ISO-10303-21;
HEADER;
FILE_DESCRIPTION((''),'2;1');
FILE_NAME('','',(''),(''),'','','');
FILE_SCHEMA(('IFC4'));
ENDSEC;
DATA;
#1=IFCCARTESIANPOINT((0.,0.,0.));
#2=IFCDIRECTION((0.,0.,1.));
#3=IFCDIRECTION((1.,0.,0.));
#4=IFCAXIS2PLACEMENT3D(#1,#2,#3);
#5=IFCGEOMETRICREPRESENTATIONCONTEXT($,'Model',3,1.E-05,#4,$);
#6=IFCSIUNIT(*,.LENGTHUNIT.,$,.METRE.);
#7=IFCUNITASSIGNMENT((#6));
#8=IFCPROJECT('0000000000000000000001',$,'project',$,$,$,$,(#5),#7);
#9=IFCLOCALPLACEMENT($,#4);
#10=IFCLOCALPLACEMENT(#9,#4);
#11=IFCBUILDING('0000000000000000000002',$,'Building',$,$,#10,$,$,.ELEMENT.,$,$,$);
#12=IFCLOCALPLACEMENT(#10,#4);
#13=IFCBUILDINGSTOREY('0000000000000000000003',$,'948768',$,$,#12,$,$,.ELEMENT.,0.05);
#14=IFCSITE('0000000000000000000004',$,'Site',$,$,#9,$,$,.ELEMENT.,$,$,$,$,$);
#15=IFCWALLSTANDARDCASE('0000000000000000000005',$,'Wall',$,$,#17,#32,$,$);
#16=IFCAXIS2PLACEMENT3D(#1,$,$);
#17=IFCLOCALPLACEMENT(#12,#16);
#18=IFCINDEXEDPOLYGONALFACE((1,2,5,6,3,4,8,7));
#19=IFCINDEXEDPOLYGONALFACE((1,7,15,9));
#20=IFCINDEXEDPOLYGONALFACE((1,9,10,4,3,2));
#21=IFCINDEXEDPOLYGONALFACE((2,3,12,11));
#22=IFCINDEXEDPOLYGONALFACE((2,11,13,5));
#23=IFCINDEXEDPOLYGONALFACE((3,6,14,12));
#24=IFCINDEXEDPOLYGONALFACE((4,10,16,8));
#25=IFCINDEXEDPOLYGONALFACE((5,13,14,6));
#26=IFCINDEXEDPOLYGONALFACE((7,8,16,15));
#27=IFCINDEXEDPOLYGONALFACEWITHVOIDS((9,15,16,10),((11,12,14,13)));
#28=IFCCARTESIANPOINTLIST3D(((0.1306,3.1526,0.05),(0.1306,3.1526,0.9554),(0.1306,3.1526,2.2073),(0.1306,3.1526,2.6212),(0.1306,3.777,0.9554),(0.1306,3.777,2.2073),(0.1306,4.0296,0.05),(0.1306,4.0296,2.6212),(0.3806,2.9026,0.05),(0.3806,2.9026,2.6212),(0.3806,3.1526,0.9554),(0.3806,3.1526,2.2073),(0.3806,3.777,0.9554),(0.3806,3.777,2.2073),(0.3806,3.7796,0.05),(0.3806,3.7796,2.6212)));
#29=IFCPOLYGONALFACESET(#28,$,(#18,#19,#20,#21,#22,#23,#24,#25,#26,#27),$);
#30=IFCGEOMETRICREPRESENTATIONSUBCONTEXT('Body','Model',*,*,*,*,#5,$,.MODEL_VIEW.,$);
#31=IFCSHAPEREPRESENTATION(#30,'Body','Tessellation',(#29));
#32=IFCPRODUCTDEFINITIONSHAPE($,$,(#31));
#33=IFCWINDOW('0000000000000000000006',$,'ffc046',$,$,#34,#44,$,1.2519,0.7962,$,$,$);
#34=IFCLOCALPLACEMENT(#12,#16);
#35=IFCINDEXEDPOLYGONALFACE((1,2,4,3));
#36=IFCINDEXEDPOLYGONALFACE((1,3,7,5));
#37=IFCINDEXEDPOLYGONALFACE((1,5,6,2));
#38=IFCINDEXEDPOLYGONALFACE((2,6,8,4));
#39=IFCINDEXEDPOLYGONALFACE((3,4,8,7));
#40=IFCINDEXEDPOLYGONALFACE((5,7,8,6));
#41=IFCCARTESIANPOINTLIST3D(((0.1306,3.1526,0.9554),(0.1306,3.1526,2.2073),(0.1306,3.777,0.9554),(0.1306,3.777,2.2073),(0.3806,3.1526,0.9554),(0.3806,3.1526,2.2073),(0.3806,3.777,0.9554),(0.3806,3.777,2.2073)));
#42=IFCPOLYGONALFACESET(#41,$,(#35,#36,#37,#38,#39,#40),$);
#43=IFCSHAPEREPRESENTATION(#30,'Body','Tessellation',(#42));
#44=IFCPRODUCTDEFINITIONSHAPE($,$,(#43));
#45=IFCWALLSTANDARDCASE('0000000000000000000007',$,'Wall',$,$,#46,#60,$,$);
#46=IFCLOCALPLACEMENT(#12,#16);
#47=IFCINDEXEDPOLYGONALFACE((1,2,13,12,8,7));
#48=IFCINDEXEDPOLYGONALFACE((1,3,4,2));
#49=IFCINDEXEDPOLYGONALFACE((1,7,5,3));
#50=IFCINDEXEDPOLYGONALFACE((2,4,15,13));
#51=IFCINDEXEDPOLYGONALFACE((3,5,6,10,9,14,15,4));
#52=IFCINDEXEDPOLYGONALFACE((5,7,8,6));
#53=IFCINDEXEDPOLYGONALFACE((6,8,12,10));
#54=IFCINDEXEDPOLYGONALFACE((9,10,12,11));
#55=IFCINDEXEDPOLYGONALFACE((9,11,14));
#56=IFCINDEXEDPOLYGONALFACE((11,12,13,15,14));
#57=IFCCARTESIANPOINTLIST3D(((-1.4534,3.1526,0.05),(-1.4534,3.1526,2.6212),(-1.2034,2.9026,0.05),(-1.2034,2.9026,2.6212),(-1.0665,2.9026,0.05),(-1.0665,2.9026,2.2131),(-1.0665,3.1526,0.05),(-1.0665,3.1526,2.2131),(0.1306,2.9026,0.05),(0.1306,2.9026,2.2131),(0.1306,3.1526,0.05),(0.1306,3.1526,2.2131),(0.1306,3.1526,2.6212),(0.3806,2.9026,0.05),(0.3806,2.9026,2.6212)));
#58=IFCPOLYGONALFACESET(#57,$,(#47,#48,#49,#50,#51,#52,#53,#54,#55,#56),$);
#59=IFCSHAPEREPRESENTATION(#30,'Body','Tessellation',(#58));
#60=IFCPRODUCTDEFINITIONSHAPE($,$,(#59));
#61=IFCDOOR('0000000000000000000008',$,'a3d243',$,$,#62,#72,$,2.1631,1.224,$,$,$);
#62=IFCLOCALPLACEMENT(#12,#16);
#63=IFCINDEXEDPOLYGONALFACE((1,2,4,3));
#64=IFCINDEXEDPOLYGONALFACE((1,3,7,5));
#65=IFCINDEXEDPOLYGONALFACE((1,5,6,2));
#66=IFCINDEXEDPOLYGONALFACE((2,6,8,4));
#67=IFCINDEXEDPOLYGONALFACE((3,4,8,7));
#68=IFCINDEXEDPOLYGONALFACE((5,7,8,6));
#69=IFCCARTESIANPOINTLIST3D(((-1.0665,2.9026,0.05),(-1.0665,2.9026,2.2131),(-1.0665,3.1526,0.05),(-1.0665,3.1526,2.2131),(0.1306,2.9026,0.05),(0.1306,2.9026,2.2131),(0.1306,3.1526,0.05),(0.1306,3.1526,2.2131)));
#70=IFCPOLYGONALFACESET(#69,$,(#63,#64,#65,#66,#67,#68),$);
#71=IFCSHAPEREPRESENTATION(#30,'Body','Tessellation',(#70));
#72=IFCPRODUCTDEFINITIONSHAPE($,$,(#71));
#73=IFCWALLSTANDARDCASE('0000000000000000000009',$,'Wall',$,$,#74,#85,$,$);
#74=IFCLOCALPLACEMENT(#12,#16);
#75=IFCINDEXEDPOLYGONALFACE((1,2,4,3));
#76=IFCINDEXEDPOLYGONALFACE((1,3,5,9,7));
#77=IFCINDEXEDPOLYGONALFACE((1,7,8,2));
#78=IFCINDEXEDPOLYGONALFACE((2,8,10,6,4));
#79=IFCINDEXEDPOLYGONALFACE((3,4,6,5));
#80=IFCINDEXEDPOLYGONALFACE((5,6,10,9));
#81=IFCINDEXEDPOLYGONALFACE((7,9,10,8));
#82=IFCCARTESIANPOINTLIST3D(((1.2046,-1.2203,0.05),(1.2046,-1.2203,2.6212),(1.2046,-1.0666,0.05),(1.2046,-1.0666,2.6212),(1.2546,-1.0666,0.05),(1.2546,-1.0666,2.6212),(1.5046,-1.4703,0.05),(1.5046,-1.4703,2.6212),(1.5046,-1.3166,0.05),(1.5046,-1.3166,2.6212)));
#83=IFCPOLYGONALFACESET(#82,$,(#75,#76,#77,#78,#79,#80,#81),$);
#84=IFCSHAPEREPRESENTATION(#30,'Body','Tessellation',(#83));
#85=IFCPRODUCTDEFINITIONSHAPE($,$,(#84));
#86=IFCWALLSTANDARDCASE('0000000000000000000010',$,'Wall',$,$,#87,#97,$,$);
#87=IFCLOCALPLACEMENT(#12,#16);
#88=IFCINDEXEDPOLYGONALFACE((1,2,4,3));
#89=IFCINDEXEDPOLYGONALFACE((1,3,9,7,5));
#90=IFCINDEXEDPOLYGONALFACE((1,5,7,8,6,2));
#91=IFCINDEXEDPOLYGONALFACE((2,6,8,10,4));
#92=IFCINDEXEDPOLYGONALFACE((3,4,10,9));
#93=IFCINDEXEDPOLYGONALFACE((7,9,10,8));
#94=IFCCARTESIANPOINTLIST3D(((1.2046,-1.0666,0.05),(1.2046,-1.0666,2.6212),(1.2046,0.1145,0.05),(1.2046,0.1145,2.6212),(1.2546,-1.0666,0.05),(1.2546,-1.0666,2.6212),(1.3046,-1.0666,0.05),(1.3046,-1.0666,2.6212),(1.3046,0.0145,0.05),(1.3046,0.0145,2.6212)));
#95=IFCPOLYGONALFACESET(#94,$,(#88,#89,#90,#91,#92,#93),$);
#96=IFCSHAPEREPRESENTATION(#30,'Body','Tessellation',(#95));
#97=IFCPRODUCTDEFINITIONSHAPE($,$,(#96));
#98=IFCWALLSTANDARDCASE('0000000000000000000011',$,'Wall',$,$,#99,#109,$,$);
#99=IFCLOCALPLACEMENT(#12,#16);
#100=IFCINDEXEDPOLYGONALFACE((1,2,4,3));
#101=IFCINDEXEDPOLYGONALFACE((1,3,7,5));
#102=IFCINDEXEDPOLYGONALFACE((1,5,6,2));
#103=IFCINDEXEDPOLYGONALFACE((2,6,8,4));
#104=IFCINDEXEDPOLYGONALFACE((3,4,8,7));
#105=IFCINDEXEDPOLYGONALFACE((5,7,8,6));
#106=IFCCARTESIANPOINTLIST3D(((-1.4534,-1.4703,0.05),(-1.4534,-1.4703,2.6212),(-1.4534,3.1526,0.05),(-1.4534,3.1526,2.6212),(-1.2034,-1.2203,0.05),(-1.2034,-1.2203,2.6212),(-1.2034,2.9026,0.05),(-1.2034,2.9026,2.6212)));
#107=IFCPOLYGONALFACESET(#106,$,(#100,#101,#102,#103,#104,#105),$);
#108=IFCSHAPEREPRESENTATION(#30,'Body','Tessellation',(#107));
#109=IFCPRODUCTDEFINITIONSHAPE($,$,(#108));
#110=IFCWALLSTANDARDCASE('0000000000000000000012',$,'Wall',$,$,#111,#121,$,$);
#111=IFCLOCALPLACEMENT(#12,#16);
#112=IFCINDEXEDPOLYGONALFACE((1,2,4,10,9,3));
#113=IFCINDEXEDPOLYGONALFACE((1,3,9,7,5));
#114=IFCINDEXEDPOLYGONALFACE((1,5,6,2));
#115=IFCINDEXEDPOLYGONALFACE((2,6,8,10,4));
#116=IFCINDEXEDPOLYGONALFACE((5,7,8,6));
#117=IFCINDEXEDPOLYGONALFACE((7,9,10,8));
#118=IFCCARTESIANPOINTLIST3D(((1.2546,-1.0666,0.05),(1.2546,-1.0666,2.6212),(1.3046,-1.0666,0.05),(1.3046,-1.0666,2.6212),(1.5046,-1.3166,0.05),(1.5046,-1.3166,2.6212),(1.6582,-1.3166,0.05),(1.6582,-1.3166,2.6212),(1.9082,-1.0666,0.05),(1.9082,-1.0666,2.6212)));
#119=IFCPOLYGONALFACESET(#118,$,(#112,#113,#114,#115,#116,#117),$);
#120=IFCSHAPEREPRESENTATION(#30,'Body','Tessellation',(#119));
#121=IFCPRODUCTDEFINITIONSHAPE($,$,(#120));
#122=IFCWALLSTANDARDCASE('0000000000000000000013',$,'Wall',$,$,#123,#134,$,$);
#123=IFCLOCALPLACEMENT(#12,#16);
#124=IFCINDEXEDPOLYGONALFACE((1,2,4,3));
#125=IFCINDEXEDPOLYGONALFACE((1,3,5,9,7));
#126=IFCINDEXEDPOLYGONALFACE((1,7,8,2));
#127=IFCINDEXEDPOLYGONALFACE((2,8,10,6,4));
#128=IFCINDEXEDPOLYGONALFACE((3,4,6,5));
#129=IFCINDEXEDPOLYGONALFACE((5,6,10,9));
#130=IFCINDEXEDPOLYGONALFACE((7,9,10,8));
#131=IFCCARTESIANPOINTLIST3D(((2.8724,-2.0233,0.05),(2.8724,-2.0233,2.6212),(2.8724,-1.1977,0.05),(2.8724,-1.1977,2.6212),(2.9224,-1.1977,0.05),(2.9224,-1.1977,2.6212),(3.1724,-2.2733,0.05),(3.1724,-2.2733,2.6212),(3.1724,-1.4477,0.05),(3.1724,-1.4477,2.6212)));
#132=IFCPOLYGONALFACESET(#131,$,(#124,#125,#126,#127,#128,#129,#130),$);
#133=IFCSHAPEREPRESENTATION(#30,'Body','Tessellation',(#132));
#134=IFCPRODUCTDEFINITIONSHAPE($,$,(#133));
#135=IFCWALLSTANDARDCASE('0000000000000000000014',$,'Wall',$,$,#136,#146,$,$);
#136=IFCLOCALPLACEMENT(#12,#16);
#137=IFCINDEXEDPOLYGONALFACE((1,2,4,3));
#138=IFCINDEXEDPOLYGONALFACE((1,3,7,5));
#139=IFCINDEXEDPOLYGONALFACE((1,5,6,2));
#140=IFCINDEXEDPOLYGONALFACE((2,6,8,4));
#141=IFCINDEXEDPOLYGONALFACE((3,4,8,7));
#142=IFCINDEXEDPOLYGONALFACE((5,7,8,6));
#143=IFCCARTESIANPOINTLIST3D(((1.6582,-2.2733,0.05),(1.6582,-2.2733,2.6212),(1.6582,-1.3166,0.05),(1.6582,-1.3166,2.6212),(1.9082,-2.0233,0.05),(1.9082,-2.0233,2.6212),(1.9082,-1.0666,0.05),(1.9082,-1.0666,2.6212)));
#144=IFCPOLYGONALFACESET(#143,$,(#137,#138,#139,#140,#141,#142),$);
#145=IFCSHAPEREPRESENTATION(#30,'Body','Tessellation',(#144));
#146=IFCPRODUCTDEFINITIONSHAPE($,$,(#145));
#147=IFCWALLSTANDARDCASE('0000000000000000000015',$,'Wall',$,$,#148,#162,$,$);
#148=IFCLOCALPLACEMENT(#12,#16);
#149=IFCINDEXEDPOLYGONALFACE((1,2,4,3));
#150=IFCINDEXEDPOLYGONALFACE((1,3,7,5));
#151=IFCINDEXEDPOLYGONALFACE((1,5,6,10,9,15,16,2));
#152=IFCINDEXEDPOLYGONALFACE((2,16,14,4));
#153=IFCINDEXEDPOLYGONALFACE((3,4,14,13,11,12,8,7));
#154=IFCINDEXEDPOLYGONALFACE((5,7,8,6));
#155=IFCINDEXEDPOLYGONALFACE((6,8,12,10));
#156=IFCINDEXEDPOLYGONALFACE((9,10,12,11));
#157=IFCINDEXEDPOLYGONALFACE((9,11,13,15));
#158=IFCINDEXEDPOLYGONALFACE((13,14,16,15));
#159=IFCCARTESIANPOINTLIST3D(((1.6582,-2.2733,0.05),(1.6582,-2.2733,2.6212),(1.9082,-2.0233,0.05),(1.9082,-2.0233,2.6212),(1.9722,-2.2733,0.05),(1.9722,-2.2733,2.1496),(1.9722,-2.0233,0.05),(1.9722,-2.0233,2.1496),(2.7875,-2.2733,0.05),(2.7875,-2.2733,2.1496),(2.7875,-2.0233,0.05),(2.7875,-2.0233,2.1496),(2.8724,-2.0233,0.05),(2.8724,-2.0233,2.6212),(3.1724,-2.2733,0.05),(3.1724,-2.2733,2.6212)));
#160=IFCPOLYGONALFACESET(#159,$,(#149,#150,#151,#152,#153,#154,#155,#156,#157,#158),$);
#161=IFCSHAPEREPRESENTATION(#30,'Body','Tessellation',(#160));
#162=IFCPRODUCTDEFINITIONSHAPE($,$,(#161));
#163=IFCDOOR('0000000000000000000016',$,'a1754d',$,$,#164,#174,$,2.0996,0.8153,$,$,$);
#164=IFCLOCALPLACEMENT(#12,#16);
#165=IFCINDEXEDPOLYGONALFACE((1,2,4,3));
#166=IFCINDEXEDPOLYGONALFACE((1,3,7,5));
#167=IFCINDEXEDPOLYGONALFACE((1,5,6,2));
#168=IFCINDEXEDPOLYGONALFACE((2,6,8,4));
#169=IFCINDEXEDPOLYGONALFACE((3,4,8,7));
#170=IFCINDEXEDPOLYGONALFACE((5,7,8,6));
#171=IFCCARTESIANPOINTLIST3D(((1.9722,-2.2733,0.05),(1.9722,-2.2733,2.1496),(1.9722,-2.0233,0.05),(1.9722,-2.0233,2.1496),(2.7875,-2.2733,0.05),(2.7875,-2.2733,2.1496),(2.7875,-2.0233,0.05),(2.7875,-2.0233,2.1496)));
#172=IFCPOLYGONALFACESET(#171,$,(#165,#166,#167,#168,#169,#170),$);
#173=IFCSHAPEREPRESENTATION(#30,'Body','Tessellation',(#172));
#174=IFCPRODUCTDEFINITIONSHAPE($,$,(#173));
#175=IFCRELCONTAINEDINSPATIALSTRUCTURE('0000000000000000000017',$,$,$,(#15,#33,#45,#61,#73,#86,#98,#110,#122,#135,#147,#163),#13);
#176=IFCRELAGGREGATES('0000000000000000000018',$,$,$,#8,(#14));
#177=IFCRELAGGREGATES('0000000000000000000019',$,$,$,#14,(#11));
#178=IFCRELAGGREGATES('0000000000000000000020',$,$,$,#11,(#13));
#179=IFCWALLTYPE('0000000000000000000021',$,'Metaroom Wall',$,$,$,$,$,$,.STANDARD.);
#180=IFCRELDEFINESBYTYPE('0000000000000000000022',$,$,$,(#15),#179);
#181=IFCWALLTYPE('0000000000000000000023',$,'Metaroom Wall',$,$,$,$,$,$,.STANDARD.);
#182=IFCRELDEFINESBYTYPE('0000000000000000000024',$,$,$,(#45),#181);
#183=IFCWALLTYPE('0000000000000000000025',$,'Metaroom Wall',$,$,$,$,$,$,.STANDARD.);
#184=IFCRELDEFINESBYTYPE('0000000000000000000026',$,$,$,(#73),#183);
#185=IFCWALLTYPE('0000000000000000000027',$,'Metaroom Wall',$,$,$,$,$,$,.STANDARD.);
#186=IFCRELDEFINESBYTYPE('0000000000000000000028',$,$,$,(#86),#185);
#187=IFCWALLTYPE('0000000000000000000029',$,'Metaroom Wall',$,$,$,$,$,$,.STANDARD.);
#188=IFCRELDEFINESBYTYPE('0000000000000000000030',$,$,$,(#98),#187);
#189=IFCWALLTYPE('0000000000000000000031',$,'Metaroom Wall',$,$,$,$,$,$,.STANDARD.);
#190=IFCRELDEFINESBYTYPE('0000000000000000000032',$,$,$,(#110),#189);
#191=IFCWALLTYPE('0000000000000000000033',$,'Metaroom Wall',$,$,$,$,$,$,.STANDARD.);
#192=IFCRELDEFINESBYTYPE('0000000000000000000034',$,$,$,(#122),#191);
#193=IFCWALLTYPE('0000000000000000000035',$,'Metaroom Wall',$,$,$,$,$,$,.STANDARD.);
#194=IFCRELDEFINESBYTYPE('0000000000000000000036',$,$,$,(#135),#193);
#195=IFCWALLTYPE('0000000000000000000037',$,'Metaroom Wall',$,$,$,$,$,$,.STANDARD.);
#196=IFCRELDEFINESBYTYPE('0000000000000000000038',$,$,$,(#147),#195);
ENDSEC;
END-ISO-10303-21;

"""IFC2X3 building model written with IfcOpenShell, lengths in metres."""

from ifc_helpers import new_model, si_unit, frame, origin_with_axes, place, context, subcontext, project, spatial, polyline, outline, extrude, type_object, element, fill, save


model = new_model("IFC2X3")

# Units and contexts
model_context = context("Model", 3, precision=1e-05, world=origin_with_axes())
body_context = subcontext(model_context, "Body", "Model", "MODEL_VIEW")
ifc_project = project(units=[si_unit("LENGTHUNIT", "METRE")], contexts=[model_context])

# Site, building, storey
site_placement = place(None, origin_with_axes())
site = spatial("IfcSite", under=ifc_project, at=site_placement, Name="Site", CompositionType="ELEMENT")
building_placement = place(site_placement, origin_with_axes())
building = spatial("IfcBuilding", under=site, at=building_placement, Name="Building", CompositionType="ELEMENT")
storey_placement = place(building_placement, frame((0.0, 0.0, 0.0), z_axis=(0.0, 0.0, 1.0), x_axis=(1.0, 0.0, 0.0)))
storey = spatial("IfcBuildingStorey", under=building, at=storey_placement, Name="948768", CompositionType="ELEMENT", Elevation=0.05)

# Wall, opening, window
wall_type_1 = type_object("IfcWallType", Name="Metaroom Wall", PredefinedType="STANDARD")
wall_1_placement = place(storey_placement, frame((0.1306, 4.0296, 0.05), z_axis=(0.0, 0.0, 1.0), x_axis=(1.0, 0.0, 0.0)))
wall_1 = element("IfcWallStandardCase", 1, at=wall_1_placement, inside=storey, type_object=wall_type_1, Name="Wall", context=body_context, shape_type="SweptSolid", body=[
    extrude(outline(polyline([(0.0, 0.0), (0.25, -0.25), (0.25, -1.127), (0.0, -0.877), (0.0, 0.0)])), origin_with_axes(), (0.0, 0.0, 1.0), 2.5712),
])
opening_1_placement = place(wall_1_placement, frame((0.25, -0.877, 0.9054), z_axis=(0.0, 0.0, 1.0), x_axis=(0.0, 1.0, 0.0)))
opening_1 = element("IfcOpeningElement", 2, at=opening_1_placement, cuts=wall_1, ObjectType="OPENING", context=body_context, shape_type="SweptSolid", body=[
    extrude(outline(polyline([(0.0, 0.0), (0.6244, 0.0), (0.6244, 1.2519), (0.0, 1.2519), (0.0, 0.0)])), frame((0.0, 0.0, 0.0), z_axis=(0.0, -1.0, 0.0), x_axis=(1.0, 0.0, 0.0)), (0.0, 0.0, -1.0), 0.2501),
])
window_1_placement = place(opening_1_placement, origin_with_axes())
window_1 = element("IfcWindow", 3, at=window_1_placement, inside=storey, Name="ffc046", OverallHeight=1.2519, OverallWidth=0.7962, context=body_context, shape_type="SweptSolid", body=[
    extrude(outline(polyline([(0.0, 0.0), (-0.6244, 0.0), (-0.6244, 1.2519), (0.0, 1.2519), (0.0, 0.0)])), frame((0.0, 0.25, 0.0), z_axis=(0.0, 1.0, 0.0), x_axis=(-1.0, 0.0, 0.0)), (0.0, 0.0, -1.0), 0.25),
])
fill(opening_1, window_1)

# Wall, opening, door
wall_type_2 = type_object("IfcWallType", Name="Metaroom Wall", PredefinedType="STANDARD")
wall_2_placement = place(storey_placement, frame((-1.4534, 3.1526, 0.05), z_axis=(0.0, 0.0, 1.0), x_axis=(1.0, 0.0, 0.0)))
wall_2 = element("IfcWallStandardCase", 4, at=wall_2_placement, inside=storey, type_object=wall_type_2, Name="Wall", context=body_context, shape_type="SweptSolid", body=[
    extrude(outline(polyline([(0.0, 0.0), (1.584, 0.0), (1.834, -0.25), (0.25, -0.25), (0.0, 0.0)])), origin_with_axes(), (0.0, 0.0, 1.0), 2.5712),
])
opening_2_placement = place(wall_2_placement, frame((0.3869, -0.25, 0.0), z_axis=(0.0, 0.0, 1.0), x_axis=(1.0, 0.0, 0.0)))
opening_2 = element("IfcOpeningElement", 5, at=opening_2_placement, cuts=wall_2, ObjectType="OPENING", context=body_context, shape_type="SweptSolid", body=[
    extrude(outline(polyline([(0.0, 0.0), (1.1971, 0.0), (1.1971, 2.1631), (0.0, 2.1631), (0.0, 0.0)])), frame((0.0, 0.0, 0.0), z_axis=(0.0, -1.0, 0.0), x_axis=(1.0, 0.0, 0.0)), (0.0, 0.0, -1.0), 0.2501),
])
door_1_placement = place(opening_2_placement, origin_with_axes())
door_1 = element("IfcDoor", 6, at=door_1_placement, inside=storey, Name="a3d243", OverallHeight=2.1631, OverallWidth=1.224, context=body_context, shape_type="SweptSolid", body=[
    extrude(outline(polyline([(0.0, 0.0), (-1.1971, 0.0), (-1.1971, 2.1631), (0.0, 2.1631), (0.0, 0.0)])), frame((0.0, 0.25, 0.0), z_axis=(0.0, 1.0, 0.0), x_axis=(-1.0, 0.0, 0.0)), (0.0, 0.0, -1.0), 0.25),
])
fill(opening_2, door_1)

# Walls
wall_type_3 = type_object("IfcWallType", Name="Metaroom Wall", PredefinedType="STANDARD")
wall_3_placement = place(storey_placement, frame((1.2046, -1.0666, 0.05), z_axis=(0.0, 0.0, 1.0), x_axis=(1.0, 0.0, 0.0)))
element("IfcWallStandardCase", 7, at=wall_3_placement, inside=storey, type_object=wall_type_3, Name="Wall", context=body_context, shape_type="SweptSolid", body=[
    extrude(outline(polyline([(0.0, 0.0), (0.05, 0.0), (0.3, -0.25), (0.3, -0.4037), (0.0, -0.1537), (0.0, 0.0)])), origin_with_axes(), (0.0, 0.0, 1.0), 2.5712),
])
wall_type_4 = type_object("IfcWallType", Name="Metaroom Wall", PredefinedType="STANDARD")
wall_4_placement = place(storey_placement, frame((1.2046, 0.1145, 0.05), z_axis=(0.0, 0.0, 1.0), x_axis=(1.0, 0.0, 0.0)))
element("IfcWallStandardCase", 8, at=wall_4_placement, inside=storey, type_object=wall_type_4, Name="Wall", context=body_context, shape_type="SweptSolid", body=[
    extrude(outline(polyline([(0.0, 0.0), (0.1, -0.1), (0.1, -1.1811), (0.05, -1.1811), (0.0, -1.1811), (0.0, 0.0)])), origin_with_axes(), (0.0, 0.0, 1.0), 2.5712),
])
wall_type_5 = type_object("IfcWallType", Name="Metaroom Wall", PredefinedType="STANDARD")
wall_5_placement = place(storey_placement, frame((-1.4534, 3.1526, 0.05), z_axis=(0.0, 0.0, 1.0), x_axis=(1.0, 0.0, 0.0)))
element("IfcWallStandardCase", 9, at=wall_5_placement, inside=storey, type_object=wall_type_5, Name="Wall", context=body_context, shape_type="SweptSolid", body=[
    extrude(outline(polyline([(0.0, 0.0), (0.25, -0.25), (0.25, -4.373), (0.0, -4.623), (0.0, 0.0)])), origin_with_axes(), (0.0, 0.0, 1.0), 2.5712),
])
wall_type_6 = type_object("IfcWallType", Name="Metaroom Wall", PredefinedType="STANDARD")
wall_6_placement = place(storey_placement, frame((1.2546, -1.0666, 0.05), z_axis=(0.0, 0.0, 1.0), x_axis=(1.0, 0.0, 0.0)))
element("IfcWallStandardCase", 10, at=wall_6_placement, inside=storey, type_object=wall_type_6, Name="Wall", context=body_context, shape_type="SweptSolid", body=[
    extrude(outline(polyline([(0.0, 0.0), (0.05, 0.0), (0.6536, 0.0), (0.4036, -0.25), (0.25, -0.25), (0.0, 0.0)])), origin_with_axes(), (0.0, 0.0, 1.0), 2.5712),
])
wall_type_7 = type_object("IfcWallType", Name="Metaroom Wall", PredefinedType="STANDARD")
wall_7_placement = place(storey_placement, frame((2.8724, -1.1977, 0.05), z_axis=(0.0, 0.0, 1.0), x_axis=(1.0, 0.0, 0.0)))
element("IfcWallStandardCase", 11, at=wall_7_placement, inside=storey, type_object=wall_type_7, Name="Wall", context=body_context, shape_type="SweptSolid", body=[
    extrude(outline(polyline([(0.0, 0.0), (0.05, 0.0), (0.3, -0.25), (0.3, -1.0757), (0.0, -0.8257), (0.0, 0.0)])), origin_with_axes(), (0.0, 0.0, 1.0), 2.5712),
])
wall_type_8 = type_object("IfcWallType", Name="Metaroom Wall", PredefinedType="STANDARD")
wall_8_placement = place(storey_placement, frame((1.6582, -1.3166, 0.05), z_axis=(0.0, 0.0, 1.0), x_axis=(1.0, 0.0, 0.0)))
element("IfcWallStandardCase", 12, at=wall_8_placement, inside=storey, type_object=wall_type_8, Name="Wall", context=body_context, shape_type="SweptSolid", body=[
    extrude(outline(polyline([(0.0, 0.0), (0.25, 0.25), (0.25, -0.7067), (0.0, -0.9567), (0.0, 0.0)])), origin_with_axes(), (0.0, 0.0, 1.0), 2.5712),
])

# Wall, opening, door
wall_type_9 = type_object("IfcWallType", Name="Metaroom Wall", PredefinedType="STANDARD")
wall_9_placement = place(storey_placement, frame((1.9082, -2.0233, 0.05), z_axis=(0.0, 0.0, 1.0), x_axis=(1.0, 0.0, 0.0)))
wall_9 = element("IfcWallStandardCase", 13, at=wall_9_placement, inside=storey, type_object=wall_type_9, Name="Wall", context=body_context, shape_type="SweptSolid", body=[
    extrude(outline(polyline([(0.0, 0.0), (0.9642, 0.0), (1.2642, -0.25), (-0.25, -0.25), (0.0, 0.0)])), origin_with_axes(), (0.0, 0.0, 1.0), 2.5712),
])
opening_3_placement = place(wall_9_placement, frame((0.8793, 0.0, 0.0), z_axis=(0.0, 0.0, 1.0), x_axis=(-1.0, 0.0, 0.0)))
opening_3 = element("IfcOpeningElement", 14, at=opening_3_placement, cuts=wall_9, ObjectType="OPENING", context=body_context, shape_type="SweptSolid", body=[
    extrude(outline(polyline([(0.0, 0.0), (0.8153, 0.0), (0.8153, 2.0996), (0.0, 2.0996), (0.0, 0.0)])), frame((0.0, 0.0, 0.0), z_axis=(0.0, -1.0, 0.0), x_axis=(1.0, 0.0, 0.0)), (0.0, 0.0, -1.0), 0.2501),
])
door_2_placement = place(opening_3_placement, origin_with_axes())
door_2 = element("IfcDoor", 15, at=door_2_placement, inside=storey, Name="a1754d", OverallHeight=2.0996, OverallWidth=0.8153, context=body_context, shape_type="SweptSolid", body=[
    extrude(outline(polyline([(0.0, 0.0), (-0.8153, 0.0), (-0.8153, 2.0996), (0.0, 2.0996), (0.0, 0.0)])), frame((0.0, 0.25, 0.0), z_axis=(0.0, 1.0, 0.0), x_axis=(-1.0, 0.0, 0.0)), (0.0, 0.0, -1.0), 0.25),
])
fill(opening_3, door_2)

save(model, "model.ifc")
